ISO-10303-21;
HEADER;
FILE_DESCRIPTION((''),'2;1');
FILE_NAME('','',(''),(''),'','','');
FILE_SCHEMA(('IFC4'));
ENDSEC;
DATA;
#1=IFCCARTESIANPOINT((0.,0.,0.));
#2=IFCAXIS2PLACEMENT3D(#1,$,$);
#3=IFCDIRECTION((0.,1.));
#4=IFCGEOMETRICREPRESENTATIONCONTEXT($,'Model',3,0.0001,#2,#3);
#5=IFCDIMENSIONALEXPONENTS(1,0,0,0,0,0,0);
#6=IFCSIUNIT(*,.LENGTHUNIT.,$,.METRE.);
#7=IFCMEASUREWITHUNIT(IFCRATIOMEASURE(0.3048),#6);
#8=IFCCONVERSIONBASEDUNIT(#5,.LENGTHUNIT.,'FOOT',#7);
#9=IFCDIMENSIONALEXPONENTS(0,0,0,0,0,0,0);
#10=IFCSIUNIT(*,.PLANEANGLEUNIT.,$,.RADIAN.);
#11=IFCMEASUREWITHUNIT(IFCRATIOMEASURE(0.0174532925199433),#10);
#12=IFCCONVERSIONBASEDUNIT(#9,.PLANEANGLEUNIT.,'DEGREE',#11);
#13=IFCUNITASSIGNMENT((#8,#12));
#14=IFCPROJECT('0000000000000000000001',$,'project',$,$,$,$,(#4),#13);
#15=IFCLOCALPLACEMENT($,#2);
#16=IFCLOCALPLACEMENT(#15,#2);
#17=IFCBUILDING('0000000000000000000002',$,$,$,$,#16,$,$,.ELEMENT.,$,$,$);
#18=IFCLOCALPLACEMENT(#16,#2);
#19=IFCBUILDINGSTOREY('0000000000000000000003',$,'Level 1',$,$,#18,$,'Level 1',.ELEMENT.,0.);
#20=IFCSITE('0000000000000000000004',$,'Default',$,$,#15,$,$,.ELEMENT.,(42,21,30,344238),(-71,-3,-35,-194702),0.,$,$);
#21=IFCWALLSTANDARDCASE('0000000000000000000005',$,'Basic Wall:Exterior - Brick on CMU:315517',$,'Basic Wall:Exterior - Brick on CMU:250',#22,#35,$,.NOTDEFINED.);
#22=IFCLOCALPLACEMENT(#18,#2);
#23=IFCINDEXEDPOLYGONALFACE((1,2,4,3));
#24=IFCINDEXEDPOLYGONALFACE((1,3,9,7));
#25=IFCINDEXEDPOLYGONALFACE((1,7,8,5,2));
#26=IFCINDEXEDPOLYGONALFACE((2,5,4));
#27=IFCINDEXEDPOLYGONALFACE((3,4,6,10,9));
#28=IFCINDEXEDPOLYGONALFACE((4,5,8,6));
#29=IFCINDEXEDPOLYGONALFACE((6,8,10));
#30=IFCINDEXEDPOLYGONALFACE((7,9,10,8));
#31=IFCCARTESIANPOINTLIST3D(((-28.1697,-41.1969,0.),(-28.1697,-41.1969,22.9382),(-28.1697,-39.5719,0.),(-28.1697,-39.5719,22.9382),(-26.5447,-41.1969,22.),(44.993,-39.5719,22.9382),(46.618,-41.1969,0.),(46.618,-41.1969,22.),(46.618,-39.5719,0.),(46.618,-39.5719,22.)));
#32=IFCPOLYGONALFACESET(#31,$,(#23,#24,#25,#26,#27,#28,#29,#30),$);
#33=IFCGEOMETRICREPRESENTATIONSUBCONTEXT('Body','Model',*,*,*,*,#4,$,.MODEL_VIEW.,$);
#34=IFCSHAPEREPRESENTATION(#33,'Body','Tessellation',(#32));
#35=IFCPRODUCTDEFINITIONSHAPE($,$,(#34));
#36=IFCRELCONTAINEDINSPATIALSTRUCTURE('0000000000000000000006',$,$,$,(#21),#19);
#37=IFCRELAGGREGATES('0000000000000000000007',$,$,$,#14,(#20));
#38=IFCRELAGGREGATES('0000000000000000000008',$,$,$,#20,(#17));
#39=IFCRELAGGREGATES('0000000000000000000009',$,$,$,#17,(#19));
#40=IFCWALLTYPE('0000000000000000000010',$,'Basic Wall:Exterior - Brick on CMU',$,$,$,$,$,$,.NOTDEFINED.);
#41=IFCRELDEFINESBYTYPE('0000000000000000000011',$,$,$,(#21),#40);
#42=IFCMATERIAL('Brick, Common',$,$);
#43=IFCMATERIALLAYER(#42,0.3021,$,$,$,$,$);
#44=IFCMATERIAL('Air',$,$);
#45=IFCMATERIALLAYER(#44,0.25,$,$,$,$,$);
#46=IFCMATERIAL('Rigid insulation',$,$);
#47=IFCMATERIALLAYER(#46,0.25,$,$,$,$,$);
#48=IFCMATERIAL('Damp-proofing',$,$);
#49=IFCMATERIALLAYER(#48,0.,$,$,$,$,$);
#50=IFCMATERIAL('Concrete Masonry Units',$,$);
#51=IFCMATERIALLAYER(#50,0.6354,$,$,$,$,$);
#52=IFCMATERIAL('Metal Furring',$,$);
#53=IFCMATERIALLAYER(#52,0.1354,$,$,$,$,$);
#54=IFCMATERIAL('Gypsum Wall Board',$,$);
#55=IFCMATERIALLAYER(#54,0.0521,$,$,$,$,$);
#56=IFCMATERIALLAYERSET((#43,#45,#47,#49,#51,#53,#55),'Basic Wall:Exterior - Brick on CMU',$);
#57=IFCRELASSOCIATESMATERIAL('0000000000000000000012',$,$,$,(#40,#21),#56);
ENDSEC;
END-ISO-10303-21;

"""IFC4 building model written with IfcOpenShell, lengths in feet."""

from ifc_helpers import new_model, entity, si_unit, converted_unit, direction, frame, frame_2d, origin, place, context, subcontext, project, spatial, polyline, rectangle, extrude, clip, bounded_halfspace, material, layer, layer_set, layer_usage, type_object, element, save


model = new_model("IFC4")

# Units and contexts
model_context = context("Model", 3, precision=0.0001, world=origin(), true_north=direction((0.0, 1.0)))
body_context = subcontext(model_context, "Body", "Model", "MODEL_VIEW")
ifc_project = project(units=[converted_unit("LENGTHUNIT", "FOOT", entity("IfcRatioMeasure", 0.3048), si_unit("LENGTHUNIT", "METRE"), dimensions=[1, 0, 0, 0, 0, 0, 0]), converted_unit("PLANEANGLEUNIT", "DEGREE", entity("IfcRatioMeasure", 0.0174532925199433), si_unit("PLANEANGLEUNIT", "RADIAN"), dimensions=[0, 0, 0, 0, 0, 0, 0])], contexts=[model_context])

# Site, building, storey
site_placement = place(None, origin())
site = spatial("IfcSite", under=ifc_project, at=site_placement, Name="Default", CompositionType="ELEMENT", RefLatitude=(42, 21, 30, 344238), RefLongitude=(-71, -3, -35, -194702), RefElevation=0.0)
building_placement = place(site_placement, origin())
building = spatial("IfcBuilding", under=site, at=building_placement, CompositionType="ELEMENT")
storey_placement = place(building_placement, origin())
storey = spatial("IfcBuildingStorey", under=building, at=storey_placement, Name="Level 1", LongName="Level 1", CompositionType="ELEMENT", Elevation=0.0)

# Wall
ifc_material_1 = material(Name="Brick, Common")
ifc_layer_1 = layer(ifc_material_1, 0.3021)
ifc_material_2 = material(Name="Air")
ifc_layer_2 = layer(ifc_material_2, 0.25)
ifc_material_3 = material(Name="Rigid insulation")
ifc_layer_3 = layer(ifc_material_3, 0.25)
ifc_material_4 = material(Name="Damp-proofing")
ifc_layer_4 = layer(ifc_material_4, 0.0)
ifc_material_5 = material(Name="Concrete Masonry Units")
ifc_layer_5 = layer(ifc_material_5, 0.6354)
ifc_material_6 = material(Name="Metal Furring")
ifc_layer_6 = layer(ifc_material_6, 0.1354)
ifc_material_7 = material(Name="Gypsum Wall Board")
ifc_layer_7 = layer(ifc_material_7, 0.0521)
ifc_layer_set = layer_set([ifc_layer_1, ifc_layer_2, ifc_layer_3, ifc_layer_4, ifc_layer_5, ifc_layer_6, ifc_layer_7], Name="Basic Wall:Exterior - Brick on CMU")
ifc_layer_usage = layer_usage(ifc_layer_set, "AXIS2", "NEGATIVE", 0.8125)
wall_type = type_object("IfcWallType", Name="Basic Wall:Exterior - Brick on CMU", PredefinedType="NOTDEFINED", material=ifc_layer_set)
wall_placement = place(storey_placement, frame((46.618, -40.3844, 0.0), z_axis=(0.0, 0.0, 1.0), x_axis=(-1.0, 0.0, 0.0)))
element("IfcWallStandardCase", 1, at=wall_placement, inside=storey, type_object=wall_type, material=ifc_layer_usage, Name="Basic Wall:Exterior - Brick on CMU:315517", ObjectType="Basic Wall:Exterior - Brick on CMU:250", PredefinedType="NOTDEFINED", context=body_context, shape_type="Clipping", body=[
    clip(clip(clip(extrude(rectangle(XDim=74.7877, YDim=1.625, at=frame_2d((37.3939, 0.0), x_axis=(-1.0, 0.0))), origin(), (0.0, 0.0, 1.0), 22.9382), bounded_halfspace(frame((74.7877, -0.8125, 22.9382), z_axis=(-0.5, 0.0, 0.866025), x_axis=(0.0, -1.0, 0.0)), False, frame((74.7877, -0.8125, 22.9382)), polyline([(0.0, 0.0), (0.0, 1.625), (-1.625, 1.625), (0.0, 0.0)]))), bounded_halfspace(frame((0.0, -0.8125, 22.0), z_axis=(-0.5, 0.0, 0.866025), x_axis=(0.0, -1.0, 0.0)), False, frame((0.0, -0.8125, 22.0)), polyline([(0.0, 0.0), (1.625, 0.0), (0.0, 1.625), (0.0, 0.0)]))), bounded_halfspace(frame((1.625, -0.8125, 22.9382), z_axis=(0.0, 0.5, 0.866025), x_axis=(-1.0, 0.0, 0.0)), False, frame((1.625, -0.8125, 22.9382)), polyline([(0.0, 0.0), (73.1627, 0.0), (71.5377, 1.625), (-1.625, 1.625), (0.0, 0.0)]))),
])

save(model, "model.ifc")
